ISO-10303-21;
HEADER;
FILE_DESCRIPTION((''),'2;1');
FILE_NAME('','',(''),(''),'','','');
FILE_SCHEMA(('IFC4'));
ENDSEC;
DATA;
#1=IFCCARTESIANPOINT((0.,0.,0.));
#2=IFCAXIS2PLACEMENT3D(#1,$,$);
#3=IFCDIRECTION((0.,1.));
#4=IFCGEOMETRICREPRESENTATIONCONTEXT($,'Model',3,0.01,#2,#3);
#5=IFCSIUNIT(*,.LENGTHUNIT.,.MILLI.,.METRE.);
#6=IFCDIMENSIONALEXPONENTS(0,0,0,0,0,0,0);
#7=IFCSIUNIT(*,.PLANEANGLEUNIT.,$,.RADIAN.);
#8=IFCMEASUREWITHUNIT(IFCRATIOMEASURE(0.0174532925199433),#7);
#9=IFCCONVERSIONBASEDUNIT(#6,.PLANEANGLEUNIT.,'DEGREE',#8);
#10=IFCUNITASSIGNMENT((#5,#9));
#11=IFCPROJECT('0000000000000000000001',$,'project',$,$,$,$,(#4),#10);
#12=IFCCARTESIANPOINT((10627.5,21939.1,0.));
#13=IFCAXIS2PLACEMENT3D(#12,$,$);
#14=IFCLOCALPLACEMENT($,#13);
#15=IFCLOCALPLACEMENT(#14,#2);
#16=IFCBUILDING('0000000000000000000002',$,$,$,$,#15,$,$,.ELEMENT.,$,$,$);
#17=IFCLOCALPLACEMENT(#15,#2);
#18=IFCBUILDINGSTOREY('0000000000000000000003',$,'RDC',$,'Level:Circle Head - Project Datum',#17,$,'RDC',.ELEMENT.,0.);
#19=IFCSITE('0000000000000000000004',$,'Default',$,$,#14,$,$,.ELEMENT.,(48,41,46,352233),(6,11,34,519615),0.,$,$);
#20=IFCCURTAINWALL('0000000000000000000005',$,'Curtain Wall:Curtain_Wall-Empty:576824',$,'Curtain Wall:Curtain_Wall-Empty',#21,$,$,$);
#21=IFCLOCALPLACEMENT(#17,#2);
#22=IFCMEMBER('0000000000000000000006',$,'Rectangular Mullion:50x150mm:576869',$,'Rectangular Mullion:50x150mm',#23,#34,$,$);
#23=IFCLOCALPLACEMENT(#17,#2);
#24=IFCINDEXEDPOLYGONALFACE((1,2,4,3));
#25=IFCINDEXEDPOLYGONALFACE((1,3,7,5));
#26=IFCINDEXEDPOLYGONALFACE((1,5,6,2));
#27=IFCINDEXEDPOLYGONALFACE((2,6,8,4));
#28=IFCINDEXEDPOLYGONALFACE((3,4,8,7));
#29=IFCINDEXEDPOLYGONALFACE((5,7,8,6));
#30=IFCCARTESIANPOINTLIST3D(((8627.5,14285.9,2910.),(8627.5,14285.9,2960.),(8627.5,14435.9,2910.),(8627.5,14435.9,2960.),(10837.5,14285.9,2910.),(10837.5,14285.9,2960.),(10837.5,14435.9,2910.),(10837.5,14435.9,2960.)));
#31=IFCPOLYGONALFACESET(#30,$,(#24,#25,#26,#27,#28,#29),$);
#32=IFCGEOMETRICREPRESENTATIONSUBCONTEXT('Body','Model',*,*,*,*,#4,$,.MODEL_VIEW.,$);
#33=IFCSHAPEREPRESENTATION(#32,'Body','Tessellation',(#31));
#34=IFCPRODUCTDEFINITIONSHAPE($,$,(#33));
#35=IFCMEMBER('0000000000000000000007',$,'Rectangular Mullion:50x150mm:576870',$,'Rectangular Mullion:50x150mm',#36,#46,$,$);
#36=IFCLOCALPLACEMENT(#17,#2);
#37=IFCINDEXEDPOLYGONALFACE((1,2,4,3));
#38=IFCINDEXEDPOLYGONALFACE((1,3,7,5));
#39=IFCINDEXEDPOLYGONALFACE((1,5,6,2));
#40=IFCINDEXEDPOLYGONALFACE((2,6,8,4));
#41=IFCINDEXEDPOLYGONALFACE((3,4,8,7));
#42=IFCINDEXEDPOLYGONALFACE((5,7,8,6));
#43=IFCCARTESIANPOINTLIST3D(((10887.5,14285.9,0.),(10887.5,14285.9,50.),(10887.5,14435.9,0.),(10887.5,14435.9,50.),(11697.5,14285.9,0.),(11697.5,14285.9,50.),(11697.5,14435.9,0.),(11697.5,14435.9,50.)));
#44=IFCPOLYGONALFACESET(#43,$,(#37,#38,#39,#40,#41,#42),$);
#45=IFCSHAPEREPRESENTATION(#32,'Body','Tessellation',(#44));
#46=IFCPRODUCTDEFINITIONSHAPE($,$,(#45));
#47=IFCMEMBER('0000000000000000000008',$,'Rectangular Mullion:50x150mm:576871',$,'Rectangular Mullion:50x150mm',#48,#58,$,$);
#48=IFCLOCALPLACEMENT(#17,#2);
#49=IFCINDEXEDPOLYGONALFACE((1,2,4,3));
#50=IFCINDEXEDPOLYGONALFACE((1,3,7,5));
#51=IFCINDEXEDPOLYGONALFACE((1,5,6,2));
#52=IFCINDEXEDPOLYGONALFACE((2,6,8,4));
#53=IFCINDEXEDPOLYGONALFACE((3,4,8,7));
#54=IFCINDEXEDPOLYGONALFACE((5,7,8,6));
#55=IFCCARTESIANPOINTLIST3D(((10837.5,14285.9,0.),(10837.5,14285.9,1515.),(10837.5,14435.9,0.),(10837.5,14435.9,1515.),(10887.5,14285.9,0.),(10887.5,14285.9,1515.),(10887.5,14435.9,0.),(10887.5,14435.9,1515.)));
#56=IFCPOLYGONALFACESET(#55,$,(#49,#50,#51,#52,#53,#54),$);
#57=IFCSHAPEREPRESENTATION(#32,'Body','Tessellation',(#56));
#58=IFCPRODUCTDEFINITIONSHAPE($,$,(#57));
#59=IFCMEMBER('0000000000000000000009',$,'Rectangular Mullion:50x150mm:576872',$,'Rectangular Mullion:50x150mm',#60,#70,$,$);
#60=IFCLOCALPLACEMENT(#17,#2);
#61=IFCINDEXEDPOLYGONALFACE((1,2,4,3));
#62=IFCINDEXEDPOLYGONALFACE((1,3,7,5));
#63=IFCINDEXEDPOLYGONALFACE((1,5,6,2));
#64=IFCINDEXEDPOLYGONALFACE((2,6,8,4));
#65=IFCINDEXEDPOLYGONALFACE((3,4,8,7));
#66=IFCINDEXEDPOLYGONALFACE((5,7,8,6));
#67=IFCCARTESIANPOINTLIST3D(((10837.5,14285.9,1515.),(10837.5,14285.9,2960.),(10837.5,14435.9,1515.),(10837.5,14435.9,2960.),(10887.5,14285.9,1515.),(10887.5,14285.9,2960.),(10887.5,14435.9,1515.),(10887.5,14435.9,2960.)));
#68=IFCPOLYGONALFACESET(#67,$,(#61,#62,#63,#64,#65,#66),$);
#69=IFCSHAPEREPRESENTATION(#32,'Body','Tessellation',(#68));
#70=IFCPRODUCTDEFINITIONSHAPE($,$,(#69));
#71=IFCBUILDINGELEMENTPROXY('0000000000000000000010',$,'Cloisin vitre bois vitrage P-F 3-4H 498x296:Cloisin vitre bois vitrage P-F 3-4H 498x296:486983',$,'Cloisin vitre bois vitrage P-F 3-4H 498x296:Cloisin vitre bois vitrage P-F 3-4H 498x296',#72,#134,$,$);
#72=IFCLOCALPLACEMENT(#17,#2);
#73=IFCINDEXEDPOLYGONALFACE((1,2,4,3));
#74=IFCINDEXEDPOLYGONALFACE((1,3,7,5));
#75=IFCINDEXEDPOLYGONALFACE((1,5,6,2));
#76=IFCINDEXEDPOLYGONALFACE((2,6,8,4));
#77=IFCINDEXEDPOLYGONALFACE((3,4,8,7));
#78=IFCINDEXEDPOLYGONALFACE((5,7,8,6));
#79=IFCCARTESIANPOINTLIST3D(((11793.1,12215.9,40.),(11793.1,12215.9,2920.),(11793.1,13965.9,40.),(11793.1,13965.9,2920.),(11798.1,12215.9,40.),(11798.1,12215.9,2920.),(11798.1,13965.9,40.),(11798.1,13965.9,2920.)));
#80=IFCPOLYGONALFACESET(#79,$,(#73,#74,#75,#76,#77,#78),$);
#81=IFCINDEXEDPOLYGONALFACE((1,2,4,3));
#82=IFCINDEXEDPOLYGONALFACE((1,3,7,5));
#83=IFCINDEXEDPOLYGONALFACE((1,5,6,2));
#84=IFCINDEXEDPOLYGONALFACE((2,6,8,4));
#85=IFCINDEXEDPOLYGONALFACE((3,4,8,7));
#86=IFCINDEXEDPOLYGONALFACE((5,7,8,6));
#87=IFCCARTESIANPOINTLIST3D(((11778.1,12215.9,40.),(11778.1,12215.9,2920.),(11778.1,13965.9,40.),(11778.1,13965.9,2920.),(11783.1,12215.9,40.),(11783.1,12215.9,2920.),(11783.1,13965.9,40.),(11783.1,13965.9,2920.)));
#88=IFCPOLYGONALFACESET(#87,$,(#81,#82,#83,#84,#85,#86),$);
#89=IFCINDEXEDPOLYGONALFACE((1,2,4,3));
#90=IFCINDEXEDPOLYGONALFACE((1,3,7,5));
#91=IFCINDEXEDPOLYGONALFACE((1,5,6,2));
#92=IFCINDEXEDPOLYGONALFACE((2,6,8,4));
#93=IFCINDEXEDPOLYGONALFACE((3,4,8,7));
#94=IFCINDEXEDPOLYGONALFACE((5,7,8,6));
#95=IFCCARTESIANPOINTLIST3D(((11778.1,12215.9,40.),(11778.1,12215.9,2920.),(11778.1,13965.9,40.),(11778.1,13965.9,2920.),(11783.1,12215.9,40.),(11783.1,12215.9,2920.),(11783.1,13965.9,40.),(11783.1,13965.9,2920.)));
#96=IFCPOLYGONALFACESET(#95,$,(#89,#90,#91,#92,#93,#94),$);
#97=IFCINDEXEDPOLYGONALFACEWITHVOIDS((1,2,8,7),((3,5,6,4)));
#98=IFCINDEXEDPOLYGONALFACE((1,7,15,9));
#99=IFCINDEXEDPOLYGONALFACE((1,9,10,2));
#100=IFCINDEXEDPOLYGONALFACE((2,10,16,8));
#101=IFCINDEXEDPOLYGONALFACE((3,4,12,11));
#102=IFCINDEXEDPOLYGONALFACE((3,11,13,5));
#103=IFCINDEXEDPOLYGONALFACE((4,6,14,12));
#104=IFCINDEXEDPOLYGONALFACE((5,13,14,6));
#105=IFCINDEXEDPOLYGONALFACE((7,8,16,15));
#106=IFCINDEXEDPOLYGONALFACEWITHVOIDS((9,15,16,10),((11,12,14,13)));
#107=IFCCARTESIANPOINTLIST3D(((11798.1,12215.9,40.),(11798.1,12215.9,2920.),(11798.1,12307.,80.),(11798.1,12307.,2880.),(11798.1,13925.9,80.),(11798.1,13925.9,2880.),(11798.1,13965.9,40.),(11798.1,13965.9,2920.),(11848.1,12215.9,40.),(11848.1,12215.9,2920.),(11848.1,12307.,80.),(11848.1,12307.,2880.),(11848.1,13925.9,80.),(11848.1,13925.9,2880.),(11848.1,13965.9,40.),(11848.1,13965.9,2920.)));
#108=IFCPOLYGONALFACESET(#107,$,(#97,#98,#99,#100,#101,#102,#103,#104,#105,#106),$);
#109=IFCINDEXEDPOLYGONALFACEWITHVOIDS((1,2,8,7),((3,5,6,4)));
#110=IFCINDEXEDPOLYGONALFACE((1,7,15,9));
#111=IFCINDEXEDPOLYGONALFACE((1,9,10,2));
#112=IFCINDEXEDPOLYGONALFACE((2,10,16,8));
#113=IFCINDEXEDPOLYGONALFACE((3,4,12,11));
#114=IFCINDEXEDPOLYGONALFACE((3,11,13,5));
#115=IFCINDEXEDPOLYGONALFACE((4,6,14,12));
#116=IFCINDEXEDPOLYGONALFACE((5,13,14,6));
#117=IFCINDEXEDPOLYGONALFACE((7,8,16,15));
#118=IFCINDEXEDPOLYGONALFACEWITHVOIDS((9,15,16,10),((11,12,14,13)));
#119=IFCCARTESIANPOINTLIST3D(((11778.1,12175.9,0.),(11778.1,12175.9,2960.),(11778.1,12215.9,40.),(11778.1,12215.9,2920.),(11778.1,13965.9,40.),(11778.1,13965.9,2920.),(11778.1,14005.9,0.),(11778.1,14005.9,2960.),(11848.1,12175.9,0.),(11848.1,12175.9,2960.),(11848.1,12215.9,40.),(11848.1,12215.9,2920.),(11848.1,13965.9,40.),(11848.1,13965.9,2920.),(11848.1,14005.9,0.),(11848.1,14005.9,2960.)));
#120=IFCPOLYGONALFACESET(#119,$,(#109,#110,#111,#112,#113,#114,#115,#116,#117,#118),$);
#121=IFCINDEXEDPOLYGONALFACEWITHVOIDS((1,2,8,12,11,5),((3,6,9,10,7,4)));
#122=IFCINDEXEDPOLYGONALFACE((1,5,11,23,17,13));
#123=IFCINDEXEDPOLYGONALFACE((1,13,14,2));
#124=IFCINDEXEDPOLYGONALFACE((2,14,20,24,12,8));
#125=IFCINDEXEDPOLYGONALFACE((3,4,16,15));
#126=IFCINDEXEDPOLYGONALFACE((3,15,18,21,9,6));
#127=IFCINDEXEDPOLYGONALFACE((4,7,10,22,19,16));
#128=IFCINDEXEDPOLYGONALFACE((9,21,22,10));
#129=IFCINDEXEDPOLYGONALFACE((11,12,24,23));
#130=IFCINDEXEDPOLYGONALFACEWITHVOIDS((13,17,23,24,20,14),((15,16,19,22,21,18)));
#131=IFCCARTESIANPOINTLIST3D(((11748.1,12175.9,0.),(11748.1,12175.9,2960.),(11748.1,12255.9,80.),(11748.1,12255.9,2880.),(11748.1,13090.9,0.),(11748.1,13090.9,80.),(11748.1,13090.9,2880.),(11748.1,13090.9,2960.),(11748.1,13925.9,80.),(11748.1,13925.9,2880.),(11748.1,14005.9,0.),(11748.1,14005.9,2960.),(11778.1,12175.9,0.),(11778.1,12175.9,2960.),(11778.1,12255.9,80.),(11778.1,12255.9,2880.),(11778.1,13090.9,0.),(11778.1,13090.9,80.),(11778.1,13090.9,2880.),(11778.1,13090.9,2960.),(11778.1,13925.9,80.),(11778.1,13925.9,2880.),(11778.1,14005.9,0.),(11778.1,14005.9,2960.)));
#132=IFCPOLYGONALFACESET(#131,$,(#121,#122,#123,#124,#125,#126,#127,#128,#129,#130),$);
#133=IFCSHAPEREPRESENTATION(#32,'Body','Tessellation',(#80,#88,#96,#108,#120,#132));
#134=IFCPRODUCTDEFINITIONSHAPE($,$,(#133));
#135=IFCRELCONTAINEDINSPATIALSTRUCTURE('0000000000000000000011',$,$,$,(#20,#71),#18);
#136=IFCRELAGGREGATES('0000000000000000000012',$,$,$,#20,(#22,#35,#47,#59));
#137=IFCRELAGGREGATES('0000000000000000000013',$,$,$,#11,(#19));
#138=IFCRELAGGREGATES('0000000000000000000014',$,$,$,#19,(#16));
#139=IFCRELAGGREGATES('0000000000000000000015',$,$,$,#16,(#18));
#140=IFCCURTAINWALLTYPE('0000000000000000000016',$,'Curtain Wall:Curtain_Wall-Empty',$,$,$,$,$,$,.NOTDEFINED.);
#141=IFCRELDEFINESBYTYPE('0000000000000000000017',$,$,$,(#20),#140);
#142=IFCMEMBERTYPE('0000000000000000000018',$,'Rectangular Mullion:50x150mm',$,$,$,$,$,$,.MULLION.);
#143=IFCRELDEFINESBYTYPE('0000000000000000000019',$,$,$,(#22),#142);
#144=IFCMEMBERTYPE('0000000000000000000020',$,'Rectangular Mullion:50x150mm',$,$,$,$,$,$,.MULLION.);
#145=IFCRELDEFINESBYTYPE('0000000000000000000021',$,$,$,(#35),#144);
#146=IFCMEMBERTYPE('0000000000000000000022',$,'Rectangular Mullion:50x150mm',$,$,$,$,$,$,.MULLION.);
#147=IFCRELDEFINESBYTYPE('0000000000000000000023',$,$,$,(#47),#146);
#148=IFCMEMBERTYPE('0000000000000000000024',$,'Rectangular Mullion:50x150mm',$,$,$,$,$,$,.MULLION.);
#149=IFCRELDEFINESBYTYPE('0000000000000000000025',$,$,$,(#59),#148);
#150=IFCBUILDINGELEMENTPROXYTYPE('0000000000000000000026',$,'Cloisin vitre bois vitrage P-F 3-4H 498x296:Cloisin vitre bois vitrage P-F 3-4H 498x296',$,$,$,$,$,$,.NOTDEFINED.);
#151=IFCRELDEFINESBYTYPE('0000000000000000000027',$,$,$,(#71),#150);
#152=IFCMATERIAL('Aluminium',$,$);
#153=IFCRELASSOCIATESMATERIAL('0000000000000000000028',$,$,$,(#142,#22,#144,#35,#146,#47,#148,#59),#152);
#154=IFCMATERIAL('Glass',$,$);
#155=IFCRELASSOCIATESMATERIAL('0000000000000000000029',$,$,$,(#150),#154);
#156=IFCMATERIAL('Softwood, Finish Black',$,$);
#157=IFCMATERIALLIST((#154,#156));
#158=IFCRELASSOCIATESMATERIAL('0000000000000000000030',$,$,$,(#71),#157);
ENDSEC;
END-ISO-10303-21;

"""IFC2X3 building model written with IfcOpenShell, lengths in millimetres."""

from ifc_helpers import new_model, entity, si_unit, converted_unit, direction, frame, frame_2d, origin, origin_2d_with_axis, place, context, subcontext, project, spatial, polyline, rectangle, outline, extrude, source, transform, mapped, material, material_list, type_object, type_shapes, element, aggregate, save


model = new_model("IFC2X3")

# Units and contexts
model_context = context("Model", 3, precision=0.01, world=origin(), true_north=direction((0.0, 1.0)))
body_context = subcontext(model_context, "Body", "Model", "MODEL_VIEW")
ifc_project = project(units=[si_unit("LENGTHUNIT", "METRE", prefix="MILLI"), converted_unit("PLANEANGLEUNIT", "DEGREE", entity("IfcRatioMeasure", 0.0174532925199433), si_unit("PLANEANGLEUNIT", "RADIAN"), dimensions=[0, 0, 0, 0, 0, 0, 0])], contexts=[model_context])

# Site, building, storey
site_placement = place(None, frame((10627.5, 21939.1, 0.0)))
site = spatial("IfcSite", under=ifc_project, at=site_placement, Name="Default", CompositionType="ELEMENT", RefLatitude=(48, 41, 46, 352233), RefLongitude=(6, 11, 34, 519615), RefElevation=0.0)
building_placement = place(site_placement, origin())
building = spatial("IfcBuilding", under=site, at=building_placement, CompositionType="ELEMENT")
storey_placement = place(building_placement, origin())
storey = spatial("IfcBuildingStorey", under=building, at=storey_placement, Name="RDC", ObjectType="Level:Circle Head - Project Datum", LongName="RDC", CompositionType="ELEMENT", Elevation=0.0)

# Curtain wall
curtain_wall_type = type_object("IfcCurtainWallType", Name="Curtain Wall:Curtain_Wall-Empty", PredefinedType="NOTDEFINED")
curtain_wall_1_placement = place(storey_placement, origin())
curtain_wall_1 = element("IfcCurtainWall", 1, at=curtain_wall_1_placement, inside=storey, type_object=curtain_wall_type, Name="Curtain Wall:Curtain_Wall-Empty:576824", ObjectType="Curtain Wall:Curtain_Wall-Empty")
ifc_material_1 = material(Name="Aluminium")

# Members
member_type_1 = type_object("IfcMemberType", Name="Rectangular Mullion:50x150mm", PredefinedType="MULLION", material=ifc_material_1)
shared_shape_1 = source(origin(), body_context, "Body", "SweptSolid", [
    extrude(rectangle(XDim=150.0, YDim=50.0, at=origin_2d_with_axis()), frame((-25.0, 0.0, -2210.0), z_axis=(0.0, 0.0, 1.0), x_axis=(0.0, -1.0, 0.0)), (0.0, 0.0, 1.0), 2210.0),
])
type_shapes(member_type_1, [shared_shape_1])
member_1_placement = place(storey_placement, frame((10837.5, 14360.9, 2960.0), z_axis=(1.0, 0.0, 0.0), x_axis=(0.0, 0.0, 1.0)))
member_1 = element("IfcMember", 2, at=member_1_placement, type_object=member_type_1, material=ifc_material_1, Name="Rectangular Mullion:50x150mm:576869", ObjectType="Rectangular Mullion:50x150mm", context=body_context, shape_type="MappedRepresentation", body=[
    mapped(shared_shape_1, transform((0.0, 0.0, 0.0), scale=1.0)),
])
member_type_2 = type_object("IfcMemberType", Name="Rectangular Mullion:50x150mm", PredefinedType="MULLION", material=ifc_material_1)
shared_shape_2 = source(origin(), body_context, "Body", "SweptSolid", [
    extrude(rectangle(XDim=150.0, YDim=50.0, at=origin_2d_with_axis()), frame((-25.0, 0.0, -810.0), z_axis=(0.0, 0.0, 1.0), x_axis=(0.0, -1.0, 0.0)), (0.0, 0.0, 1.0), 810.0),
])
type_shapes(member_type_2, [shared_shape_2])
member_2_placement = place(storey_placement, frame((10887.5, 14360.9, 0.0), z_axis=(-1.0, 0.0, 0.0), x_axis=(0.0, 0.0, -1.0)))
member_2 = element("IfcMember", 3, at=member_2_placement, type_object=member_type_2, material=ifc_material_1, Name="Rectangular Mullion:50x150mm:576870", ObjectType="Rectangular Mullion:50x150mm", context=body_context, shape_type="MappedRepresentation", body=[
    mapped(shared_shape_2, transform((0.0, 0.0, 0.0), scale=1.0)),
])
member_type_3 = type_object("IfcMemberType", Name="Rectangular Mullion:50x150mm", PredefinedType="MULLION", material=ifc_material_1)
shared_shape_3 = source(origin(), body_context, "Body", "SweptSolid", [
    extrude(rectangle(XDim=150.0, YDim=50.0, at=origin_2d_with_axis()), frame((0.0, 0.0, -1515.0), z_axis=(0.0, 0.0, 1.0), x_axis=(0.0, -1.0, 0.0)), (0.0, 0.0, 1.0), 1515.0),
])
type_shapes(member_type_3, [shared_shape_3])
member_3_placement = place(storey_placement, frame((10862.5, 14360.9, 0.0), z_axis=(0.0, 0.0, -1.0), x_axis=(1.0, 0.0, 0.0)))
member_3 = element("IfcMember", 4, at=member_3_placement, type_object=member_type_3, material=ifc_material_1, Name="Rectangular Mullion:50x150mm:576871", ObjectType="Rectangular Mullion:50x150mm", context=body_context, shape_type="MappedRepresentation", body=[
    mapped(shared_shape_3, transform((0.0, 0.0, 0.0), scale=1.0)),
])
member_type_4 = type_object("IfcMemberType", Name="Rectangular Mullion:50x150mm", PredefinedType="MULLION", material=ifc_material_1)
shared_shape_4 = source(origin(), body_context, "Body", "SweptSolid", [
    extrude(rectangle(XDim=150.0, YDim=50.0, at=origin_2d_with_axis()), frame((0.0, 0.0, -1445.0), z_axis=(0.0, 0.0, 1.0), x_axis=(0.0, -1.0, 0.0)), (0.0, 0.0, 1.0), 1445.0),
])
type_shapes(member_type_4, [shared_shape_4])
member_4_placement = place(storey_placement, frame((10862.5, 14360.9, 1515.0), z_axis=(0.0, 0.0, -1.0), x_axis=(1.0, 0.0, 0.0)))
member_4 = element("IfcMember", 5, at=member_4_placement, type_object=member_type_4, material=ifc_material_1, Name="Rectangular Mullion:50x150mm:576872", ObjectType="Rectangular Mullion:50x150mm", context=body_context, shape_type="MappedRepresentation", body=[
    mapped(shared_shape_4, transform((0.0, 0.0, 0.0), scale=1.0)),
])

# Shared definitions
ifc_material_2 = material(Name="Glass")
aggregate(curtain_wall_1, [member_1, member_2, member_3, member_4])

# Building element proxy
ifc_material_3 = material(Name="Softwood, Finish Black")
ifc_material_list_1 = material_list([ifc_material_2, ifc_material_3])
building_element_proxy_type = type_object("IfcBuildingElementProxyType", Name="Cloisin vitre bois vitrage P-F 3-4H 498x296:Cloisin vitre bois vitrage P-F 3-4H 498x296", PredefinedType="NOTDEFINED", material=ifc_material_2)
shared_shape_5 = source(origin(), body_context, "Body", "SweptSolid", [
    extrude(rectangle(XDim=1750.0, YDim=5.0, at=frame_2d((0.0, 0.0), x_axis=(1.0, 0.0))), frame((0.0, 47.5, 40.0), z_axis=(0.0, 0.0, 1.0), x_axis=(-1.0, 0.0, 0.0)), (0.0, 0.0, 1.0), 2880.0),
    extrude(rectangle(XDim=1750.0, YDim=5.0, at=frame_2d((0.0, 0.0), x_axis=(1.0, 0.0))), frame((0.0, 32.5, 40.0), z_axis=(0.0, 0.0, 1.0), x_axis=(-1.0, 0.0, 0.0)), (0.0, 0.0, 1.0), 2880.0),
    extrude(rectangle(XDim=1750.0, YDim=5.0, at=frame_2d((0.0, 0.0), x_axis=(1.0, 0.0))), frame((0.0, 32.5, 40.0), z_axis=(0.0, 0.0, 1.0), x_axis=(-1.0, 0.0, 0.0)), (0.0, 0.0, 1.0), 2880.0),
    extrude(outline(polyline([(-1440.0, -875.0), (1440.0, -875.0), (1440.0, 875.0), (-1440.0, 875.0), (-1440.0, -875.0)]), holes=[polyline([(1400.0, 835.0), (1400.0, -783.9), (-1400.0, -783.9), (-1400.0, 835.0), (1400.0, 835.0)])]), frame((0.0, 50.0, 1480.0), z_axis=(0.0, 1.0, 0.0), x_axis=(0.0, 0.0, -1.0)), (0.0, 0.0, 1.0), 50.0),
    extrude(outline(polyline([(-1480.0, -915.0), (1480.0, -915.0), (1480.0, 915.0), (-1480.0, 915.0), (-1480.0, -915.0)]), holes=[polyline([(-1440.0, -875.0), (-1440.0, 875.0), (1440.0, 875.0), (1440.0, -875.0), (-1440.0, -875.0)])]), frame((0.0, 30.0, 1480.0), z_axis=(0.0, 1.0, 0.0), x_axis=(0.0, 0.0, -1.0)), (0.0, 0.0, 1.0), 70.0),
    extrude(outline(polyline([(-1480.0, -915.0), (1480.0, -915.0), (1480.0, 0.0), (1480.0, 915.0), (-1480.0, 915.0), (-1480.0, 0.0), (-1480.0, -915.0)]), holes=[polyline([(1400.0, 0.0), (1400.0, -835.0), (-1400.0, -835.0), (-1400.0, 0.0), (-1400.0, 835.0), (1400.0, 835.0), (1400.0, 0.0)])]), frame((0.0, 0.0, 1480.0), z_axis=(0.0, 1.0, 0.0), x_axis=(0.0, 0.0, 1.0)), (0.0, 0.0, 1.0), 30.0),
])
type_shapes(building_element_proxy_type, [shared_shape_5])
proxy_1_placement = place(storey_placement, frame((11748.1, 13090.9, 0.0), z_axis=(0.0, 0.0, 1.0), x_axis=(0.0, -1.0, 0.0)))
element("IfcBuildingElementProxy", 6, at=proxy_1_placement, inside=storey, type_object=building_element_proxy_type, material=ifc_material_list_1, Name="Cloisin vitre bois vitrage P-F 3-4H 498x296:Cloisin vitre bois vitrage P-F 3-4H 498x296:486983", ObjectType="Cloisin vitre bois vitrage P-F 3-4H 498x296:Cloisin vitre bois vitrage P-F 3-4H 498x296", context=body_context, shape_type="MappedRepresentation", body=[
    mapped(shared_shape_5, transform((0.0, 0.0, 0.0), scale=1.0)),
])

save(model, "model.ifc")
